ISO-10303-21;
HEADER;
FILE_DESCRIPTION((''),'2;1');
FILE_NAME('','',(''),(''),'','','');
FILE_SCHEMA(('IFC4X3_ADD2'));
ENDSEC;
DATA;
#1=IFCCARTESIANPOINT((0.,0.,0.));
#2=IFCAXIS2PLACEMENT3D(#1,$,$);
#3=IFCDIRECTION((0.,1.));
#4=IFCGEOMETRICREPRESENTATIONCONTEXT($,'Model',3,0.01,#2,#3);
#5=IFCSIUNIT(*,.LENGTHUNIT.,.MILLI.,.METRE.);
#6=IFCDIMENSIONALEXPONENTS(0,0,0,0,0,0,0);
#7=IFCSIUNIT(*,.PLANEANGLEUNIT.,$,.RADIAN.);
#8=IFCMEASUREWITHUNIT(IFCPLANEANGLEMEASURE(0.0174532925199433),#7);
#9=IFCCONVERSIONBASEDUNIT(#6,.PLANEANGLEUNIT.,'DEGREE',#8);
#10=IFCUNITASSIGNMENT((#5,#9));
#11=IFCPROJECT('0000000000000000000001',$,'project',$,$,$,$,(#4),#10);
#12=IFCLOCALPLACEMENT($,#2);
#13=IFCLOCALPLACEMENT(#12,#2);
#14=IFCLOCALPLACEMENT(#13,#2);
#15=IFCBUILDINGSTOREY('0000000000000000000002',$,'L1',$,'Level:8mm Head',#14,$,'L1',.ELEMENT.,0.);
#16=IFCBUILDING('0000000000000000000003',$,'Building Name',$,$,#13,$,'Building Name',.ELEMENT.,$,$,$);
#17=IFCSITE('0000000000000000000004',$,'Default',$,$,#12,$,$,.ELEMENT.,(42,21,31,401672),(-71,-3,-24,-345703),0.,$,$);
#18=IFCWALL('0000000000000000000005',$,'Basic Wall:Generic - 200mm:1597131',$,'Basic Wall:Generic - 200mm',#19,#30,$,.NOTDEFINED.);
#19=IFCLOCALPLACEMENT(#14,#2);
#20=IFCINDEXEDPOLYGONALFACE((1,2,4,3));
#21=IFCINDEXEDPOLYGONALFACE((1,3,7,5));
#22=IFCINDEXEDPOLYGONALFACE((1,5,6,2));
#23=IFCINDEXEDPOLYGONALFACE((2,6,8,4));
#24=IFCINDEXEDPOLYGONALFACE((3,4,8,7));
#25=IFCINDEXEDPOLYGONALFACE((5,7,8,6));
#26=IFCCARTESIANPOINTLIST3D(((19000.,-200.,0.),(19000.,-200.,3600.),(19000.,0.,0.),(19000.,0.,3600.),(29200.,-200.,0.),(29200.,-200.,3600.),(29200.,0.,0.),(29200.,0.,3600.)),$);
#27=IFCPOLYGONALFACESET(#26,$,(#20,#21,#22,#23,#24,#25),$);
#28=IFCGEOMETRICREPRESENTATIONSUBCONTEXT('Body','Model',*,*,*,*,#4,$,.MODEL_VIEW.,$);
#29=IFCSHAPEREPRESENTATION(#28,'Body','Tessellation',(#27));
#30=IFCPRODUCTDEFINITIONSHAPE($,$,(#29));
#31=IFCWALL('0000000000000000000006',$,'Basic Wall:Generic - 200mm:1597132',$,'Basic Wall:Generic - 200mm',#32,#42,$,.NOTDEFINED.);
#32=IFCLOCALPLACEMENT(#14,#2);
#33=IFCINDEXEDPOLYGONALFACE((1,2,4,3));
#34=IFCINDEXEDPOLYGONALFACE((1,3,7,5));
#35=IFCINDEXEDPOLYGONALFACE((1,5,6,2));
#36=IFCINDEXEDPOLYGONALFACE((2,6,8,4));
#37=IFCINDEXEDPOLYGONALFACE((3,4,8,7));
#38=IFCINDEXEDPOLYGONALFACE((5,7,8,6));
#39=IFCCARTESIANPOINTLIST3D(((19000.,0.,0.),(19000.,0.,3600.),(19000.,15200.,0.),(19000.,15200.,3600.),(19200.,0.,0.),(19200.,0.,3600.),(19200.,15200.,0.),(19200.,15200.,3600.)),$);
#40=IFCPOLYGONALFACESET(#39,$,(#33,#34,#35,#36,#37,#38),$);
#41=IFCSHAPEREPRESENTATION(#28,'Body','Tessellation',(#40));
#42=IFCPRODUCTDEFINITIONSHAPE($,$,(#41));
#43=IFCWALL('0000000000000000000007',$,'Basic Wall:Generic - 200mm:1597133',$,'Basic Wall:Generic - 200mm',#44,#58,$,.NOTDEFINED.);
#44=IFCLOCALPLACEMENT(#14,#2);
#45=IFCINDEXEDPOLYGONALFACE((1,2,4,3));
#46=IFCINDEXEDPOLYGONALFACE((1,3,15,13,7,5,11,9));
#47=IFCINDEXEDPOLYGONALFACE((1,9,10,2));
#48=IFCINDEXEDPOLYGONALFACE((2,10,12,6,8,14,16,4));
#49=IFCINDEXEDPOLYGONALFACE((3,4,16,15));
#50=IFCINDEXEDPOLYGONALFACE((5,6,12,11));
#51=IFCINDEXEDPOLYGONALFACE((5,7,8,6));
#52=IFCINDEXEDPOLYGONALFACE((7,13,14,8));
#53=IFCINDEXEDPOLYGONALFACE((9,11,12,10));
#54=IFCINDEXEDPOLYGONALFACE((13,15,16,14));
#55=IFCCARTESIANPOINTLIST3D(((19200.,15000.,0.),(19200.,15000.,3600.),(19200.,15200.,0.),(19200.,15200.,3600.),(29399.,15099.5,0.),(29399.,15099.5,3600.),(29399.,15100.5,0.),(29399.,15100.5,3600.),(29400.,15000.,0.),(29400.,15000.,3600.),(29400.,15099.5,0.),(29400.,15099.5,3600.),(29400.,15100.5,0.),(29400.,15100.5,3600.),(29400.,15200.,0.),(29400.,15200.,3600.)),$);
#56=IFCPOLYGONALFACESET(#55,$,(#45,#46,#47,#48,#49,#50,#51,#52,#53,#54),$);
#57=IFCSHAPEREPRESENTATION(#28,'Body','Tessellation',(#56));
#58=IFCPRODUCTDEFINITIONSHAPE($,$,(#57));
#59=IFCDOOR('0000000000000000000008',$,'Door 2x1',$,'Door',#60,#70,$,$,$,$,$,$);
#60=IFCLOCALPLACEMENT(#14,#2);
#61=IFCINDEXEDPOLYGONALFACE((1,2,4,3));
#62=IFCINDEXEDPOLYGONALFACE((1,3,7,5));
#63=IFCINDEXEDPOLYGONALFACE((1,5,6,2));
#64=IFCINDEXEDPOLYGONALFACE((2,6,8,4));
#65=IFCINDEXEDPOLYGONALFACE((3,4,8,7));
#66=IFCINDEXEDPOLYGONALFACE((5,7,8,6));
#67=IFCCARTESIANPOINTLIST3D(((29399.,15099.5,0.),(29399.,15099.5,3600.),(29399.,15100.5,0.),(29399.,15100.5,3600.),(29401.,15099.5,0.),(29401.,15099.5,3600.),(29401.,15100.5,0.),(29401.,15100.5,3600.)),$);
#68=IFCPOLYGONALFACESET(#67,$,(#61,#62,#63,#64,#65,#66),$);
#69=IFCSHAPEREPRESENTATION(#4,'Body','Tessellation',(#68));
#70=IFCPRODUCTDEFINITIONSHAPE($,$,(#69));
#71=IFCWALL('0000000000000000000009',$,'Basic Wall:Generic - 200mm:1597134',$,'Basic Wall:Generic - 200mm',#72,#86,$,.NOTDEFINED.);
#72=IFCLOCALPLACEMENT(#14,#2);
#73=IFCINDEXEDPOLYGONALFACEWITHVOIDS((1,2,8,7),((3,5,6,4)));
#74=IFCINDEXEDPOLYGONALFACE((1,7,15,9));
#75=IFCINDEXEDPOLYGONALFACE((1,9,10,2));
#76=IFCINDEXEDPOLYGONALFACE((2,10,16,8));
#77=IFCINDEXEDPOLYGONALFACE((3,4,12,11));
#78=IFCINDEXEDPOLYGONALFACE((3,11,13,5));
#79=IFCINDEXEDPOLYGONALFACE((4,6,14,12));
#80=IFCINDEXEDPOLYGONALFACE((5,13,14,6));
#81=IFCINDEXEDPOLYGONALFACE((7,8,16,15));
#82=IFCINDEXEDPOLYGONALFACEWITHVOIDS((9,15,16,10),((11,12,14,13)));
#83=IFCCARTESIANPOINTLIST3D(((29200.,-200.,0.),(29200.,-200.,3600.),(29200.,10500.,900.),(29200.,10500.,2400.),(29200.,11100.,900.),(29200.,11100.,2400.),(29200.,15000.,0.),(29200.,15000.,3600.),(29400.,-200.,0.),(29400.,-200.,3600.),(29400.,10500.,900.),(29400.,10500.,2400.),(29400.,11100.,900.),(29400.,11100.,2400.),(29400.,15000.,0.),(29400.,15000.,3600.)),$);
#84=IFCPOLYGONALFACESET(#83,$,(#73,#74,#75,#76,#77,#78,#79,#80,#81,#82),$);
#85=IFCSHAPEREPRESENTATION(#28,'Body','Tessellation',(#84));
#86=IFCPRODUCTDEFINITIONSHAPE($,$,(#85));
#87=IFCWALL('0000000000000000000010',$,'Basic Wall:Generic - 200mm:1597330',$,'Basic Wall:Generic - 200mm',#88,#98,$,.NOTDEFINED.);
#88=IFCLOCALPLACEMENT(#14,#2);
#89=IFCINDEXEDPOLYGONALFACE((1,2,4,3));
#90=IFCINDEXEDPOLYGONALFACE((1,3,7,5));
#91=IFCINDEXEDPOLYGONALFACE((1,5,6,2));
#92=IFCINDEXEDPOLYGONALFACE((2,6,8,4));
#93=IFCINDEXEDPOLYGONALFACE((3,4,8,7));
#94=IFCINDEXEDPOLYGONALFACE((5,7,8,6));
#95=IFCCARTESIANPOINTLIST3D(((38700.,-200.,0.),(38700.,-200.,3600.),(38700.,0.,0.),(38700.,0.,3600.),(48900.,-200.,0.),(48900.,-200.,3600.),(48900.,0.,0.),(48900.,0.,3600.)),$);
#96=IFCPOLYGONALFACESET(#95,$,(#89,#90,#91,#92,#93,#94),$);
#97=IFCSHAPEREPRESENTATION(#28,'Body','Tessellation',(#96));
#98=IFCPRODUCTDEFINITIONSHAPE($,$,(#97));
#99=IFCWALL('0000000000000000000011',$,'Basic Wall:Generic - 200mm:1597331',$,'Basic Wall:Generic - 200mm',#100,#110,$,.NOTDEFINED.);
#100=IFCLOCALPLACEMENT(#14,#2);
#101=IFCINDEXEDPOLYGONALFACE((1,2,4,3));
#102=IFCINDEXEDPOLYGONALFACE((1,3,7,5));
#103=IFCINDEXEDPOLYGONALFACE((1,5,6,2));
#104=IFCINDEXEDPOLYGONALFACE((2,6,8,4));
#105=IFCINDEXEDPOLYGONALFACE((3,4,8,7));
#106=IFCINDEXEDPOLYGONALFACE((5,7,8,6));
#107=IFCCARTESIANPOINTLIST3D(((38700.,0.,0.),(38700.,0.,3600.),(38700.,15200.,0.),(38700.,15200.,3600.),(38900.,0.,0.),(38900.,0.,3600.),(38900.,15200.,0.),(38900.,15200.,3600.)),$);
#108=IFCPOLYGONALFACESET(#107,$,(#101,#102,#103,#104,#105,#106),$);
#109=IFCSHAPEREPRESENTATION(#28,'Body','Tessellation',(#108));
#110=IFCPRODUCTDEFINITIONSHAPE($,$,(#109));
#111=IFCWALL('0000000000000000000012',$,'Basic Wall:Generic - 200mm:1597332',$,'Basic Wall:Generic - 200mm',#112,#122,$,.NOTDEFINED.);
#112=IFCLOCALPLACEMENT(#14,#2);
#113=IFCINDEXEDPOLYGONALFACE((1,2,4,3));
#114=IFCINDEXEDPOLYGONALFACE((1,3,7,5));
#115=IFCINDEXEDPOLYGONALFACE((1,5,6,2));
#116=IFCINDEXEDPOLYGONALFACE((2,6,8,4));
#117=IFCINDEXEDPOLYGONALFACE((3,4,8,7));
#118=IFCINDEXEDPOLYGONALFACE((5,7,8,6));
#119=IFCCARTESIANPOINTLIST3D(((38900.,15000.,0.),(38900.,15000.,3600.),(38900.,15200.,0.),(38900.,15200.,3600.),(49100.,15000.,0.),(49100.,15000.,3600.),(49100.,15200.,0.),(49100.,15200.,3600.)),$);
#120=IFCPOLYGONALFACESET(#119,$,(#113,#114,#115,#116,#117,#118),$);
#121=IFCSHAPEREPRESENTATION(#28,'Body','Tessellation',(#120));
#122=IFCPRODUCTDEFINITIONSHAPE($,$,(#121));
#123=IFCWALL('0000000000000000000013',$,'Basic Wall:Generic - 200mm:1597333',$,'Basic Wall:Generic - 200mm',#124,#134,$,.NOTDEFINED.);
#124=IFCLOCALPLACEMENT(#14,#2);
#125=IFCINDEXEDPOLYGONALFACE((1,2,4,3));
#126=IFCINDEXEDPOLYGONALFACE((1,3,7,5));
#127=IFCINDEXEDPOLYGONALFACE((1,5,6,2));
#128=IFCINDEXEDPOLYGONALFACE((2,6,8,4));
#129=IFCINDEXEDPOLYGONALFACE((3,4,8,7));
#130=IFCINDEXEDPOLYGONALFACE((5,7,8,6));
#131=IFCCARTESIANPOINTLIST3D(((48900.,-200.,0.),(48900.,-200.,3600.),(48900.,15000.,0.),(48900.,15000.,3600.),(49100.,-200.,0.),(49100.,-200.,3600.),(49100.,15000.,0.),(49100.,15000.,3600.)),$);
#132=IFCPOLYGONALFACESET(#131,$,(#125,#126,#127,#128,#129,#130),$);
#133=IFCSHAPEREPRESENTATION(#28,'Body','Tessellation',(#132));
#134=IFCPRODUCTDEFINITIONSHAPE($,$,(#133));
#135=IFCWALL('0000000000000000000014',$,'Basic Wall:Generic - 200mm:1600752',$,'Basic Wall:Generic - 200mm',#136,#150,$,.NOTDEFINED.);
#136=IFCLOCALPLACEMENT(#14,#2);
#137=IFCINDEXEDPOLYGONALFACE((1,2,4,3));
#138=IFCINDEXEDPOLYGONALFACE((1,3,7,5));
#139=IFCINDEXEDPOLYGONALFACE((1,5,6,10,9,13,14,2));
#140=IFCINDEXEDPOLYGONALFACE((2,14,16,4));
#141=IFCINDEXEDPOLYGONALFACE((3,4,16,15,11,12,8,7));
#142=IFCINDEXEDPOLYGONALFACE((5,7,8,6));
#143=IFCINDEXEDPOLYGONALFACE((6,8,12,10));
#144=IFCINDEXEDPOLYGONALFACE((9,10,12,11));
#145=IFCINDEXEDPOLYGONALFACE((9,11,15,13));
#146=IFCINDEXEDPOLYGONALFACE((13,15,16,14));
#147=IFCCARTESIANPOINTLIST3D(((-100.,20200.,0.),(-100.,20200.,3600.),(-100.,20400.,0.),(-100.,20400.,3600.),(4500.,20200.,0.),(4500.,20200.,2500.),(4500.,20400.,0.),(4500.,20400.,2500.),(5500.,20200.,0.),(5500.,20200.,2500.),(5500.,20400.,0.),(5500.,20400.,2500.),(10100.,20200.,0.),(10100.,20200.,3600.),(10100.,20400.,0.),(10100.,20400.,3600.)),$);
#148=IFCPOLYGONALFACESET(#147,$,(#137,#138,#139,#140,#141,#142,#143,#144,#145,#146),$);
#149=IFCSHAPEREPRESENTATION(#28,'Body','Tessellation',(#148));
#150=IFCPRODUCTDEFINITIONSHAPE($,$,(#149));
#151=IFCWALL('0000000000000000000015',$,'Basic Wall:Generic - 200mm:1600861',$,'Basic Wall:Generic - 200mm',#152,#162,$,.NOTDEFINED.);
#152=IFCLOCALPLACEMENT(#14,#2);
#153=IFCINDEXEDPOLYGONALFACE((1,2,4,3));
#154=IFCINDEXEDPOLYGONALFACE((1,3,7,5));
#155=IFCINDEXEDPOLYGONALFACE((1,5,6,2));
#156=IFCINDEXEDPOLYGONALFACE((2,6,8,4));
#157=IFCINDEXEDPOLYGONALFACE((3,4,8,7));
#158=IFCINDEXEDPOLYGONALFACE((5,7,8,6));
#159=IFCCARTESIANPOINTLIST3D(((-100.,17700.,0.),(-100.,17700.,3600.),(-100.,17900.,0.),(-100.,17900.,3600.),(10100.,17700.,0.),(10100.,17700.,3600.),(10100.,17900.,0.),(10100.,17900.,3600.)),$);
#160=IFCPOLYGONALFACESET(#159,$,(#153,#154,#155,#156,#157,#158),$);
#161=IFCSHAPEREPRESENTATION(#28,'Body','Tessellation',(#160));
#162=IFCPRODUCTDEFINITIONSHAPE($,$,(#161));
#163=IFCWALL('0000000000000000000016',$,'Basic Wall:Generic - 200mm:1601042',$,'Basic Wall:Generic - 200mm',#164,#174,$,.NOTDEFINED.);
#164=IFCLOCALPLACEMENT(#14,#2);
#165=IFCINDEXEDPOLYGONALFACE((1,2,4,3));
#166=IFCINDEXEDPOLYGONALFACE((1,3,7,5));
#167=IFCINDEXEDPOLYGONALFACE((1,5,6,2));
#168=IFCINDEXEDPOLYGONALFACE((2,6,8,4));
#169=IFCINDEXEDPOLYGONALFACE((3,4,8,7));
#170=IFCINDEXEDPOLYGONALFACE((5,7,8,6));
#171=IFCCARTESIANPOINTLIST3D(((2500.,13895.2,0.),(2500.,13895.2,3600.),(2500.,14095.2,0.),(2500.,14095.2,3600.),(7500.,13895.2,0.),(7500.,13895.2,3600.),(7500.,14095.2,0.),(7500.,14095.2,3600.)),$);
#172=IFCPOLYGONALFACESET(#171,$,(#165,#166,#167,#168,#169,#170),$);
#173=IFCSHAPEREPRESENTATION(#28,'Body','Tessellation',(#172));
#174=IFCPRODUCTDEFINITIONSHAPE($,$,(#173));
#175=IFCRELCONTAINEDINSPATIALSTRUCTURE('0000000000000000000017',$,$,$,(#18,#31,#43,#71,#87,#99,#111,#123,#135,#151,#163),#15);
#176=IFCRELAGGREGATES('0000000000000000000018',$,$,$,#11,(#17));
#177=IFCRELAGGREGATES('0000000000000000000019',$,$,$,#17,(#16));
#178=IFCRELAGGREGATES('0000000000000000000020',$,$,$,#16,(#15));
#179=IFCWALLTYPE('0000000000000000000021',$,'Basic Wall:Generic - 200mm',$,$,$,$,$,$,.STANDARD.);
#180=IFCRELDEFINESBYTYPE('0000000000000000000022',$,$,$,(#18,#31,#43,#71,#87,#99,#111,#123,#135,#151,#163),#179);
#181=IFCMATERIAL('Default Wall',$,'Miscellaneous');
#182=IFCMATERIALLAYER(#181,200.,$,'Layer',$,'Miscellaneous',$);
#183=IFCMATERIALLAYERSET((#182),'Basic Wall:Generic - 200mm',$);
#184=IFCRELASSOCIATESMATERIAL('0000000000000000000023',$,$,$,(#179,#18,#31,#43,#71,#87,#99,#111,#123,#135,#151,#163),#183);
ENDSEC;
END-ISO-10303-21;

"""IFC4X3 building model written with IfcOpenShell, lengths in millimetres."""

from ifc_helpers import new_model, entity, si_unit, converted_unit, direction, frame, frame_2d, origin, origin_2d, origin_2d_with_axis, place, context, subcontext, project, spatial, rectangle, extrude, material, layer, layer_set, type_object, element, fill, save


model = new_model("IFC4X3")

# Units and contexts
model_context = context("Model", 3, precision=0.01, world=origin(), true_north=direction((0.0, 1.0)))
body_context = subcontext(model_context, "Body", "Model", "MODEL_VIEW")
ifc_project = project(units=[si_unit("LENGTHUNIT", "METRE", prefix="MILLI"), converted_unit("PLANEANGLEUNIT", "DEGREE", entity("IfcPlaneAngleMeasure", 0.0174532925199433), si_unit("PLANEANGLEUNIT", "RADIAN"), dimensions=[0, 0, 0, 0, 0, 0, 0])], contexts=[model_context])

# Site, building, storey
site_placement = place(None, origin())
site = spatial("IfcSite", under=ifc_project, at=site_placement, Name="Default", CompositionType="ELEMENT", RefLatitude=(42, 21, 31, 401672), RefLongitude=(-71, -3, -24, -345703), RefElevation=0.0)
building_placement = place(site_placement, origin())
building = spatial("IfcBuilding", under=site, at=building_placement, Name="Building Name", LongName="Building Name", CompositionType="ELEMENT")
storey_placement = place(building_placement, origin())
storey = spatial("IfcBuildingStorey", under=building, at=storey_placement, Name="L1", ObjectType="Level:8mm Head", LongName="L1", CompositionType="ELEMENT", Elevation=0.0)

# Walls
ifc_material_1 = material(Name="Default Wall", Category="Miscellaneous")
ifc_layer_1 = layer(ifc_material_1, 200.0, Name="Layer", Category="Miscellaneous")
ifc_layer_set_1 = layer_set([ifc_layer_1], Name="Basic Wall:Generic - 200mm")
wall_type_1 = type_object("IfcWallType", Name="Basic Wall:Generic - 200mm", PredefinedType="STANDARD", material=ifc_layer_set_1)
wall_1_placement = place(storey_placement, frame((19000.0, -100.0, 0.0)))
element("IfcWall", 1, at=wall_1_placement, inside=storey, type_object=wall_type_1, material=ifc_layer_set_1, Name="Basic Wall:Generic - 200mm:1597131", ObjectType="Basic Wall:Generic - 200mm", PredefinedType="NOTDEFINED", context=body_context, shape_type="SweptSolid", body=[
    extrude(rectangle(XDim=10200.0, YDim=200.0, at=frame_2d((5100.0, 0.0), x_axis=(-1.0, 0.0))), origin(), (0.0, 0.0, 1.0), 3600.0),
])
wall_2_placement = place(storey_placement, frame((19100.0, 15200.0, 0.0), z_axis=(0.0, 0.0, 1.0), x_axis=(0.0, -1.0, 0.0)))
element("IfcWall", 2, at=wall_2_placement, inside=storey, type_object=wall_type_1, material=ifc_layer_set_1, Name="Basic Wall:Generic - 200mm:1597132", ObjectType="Basic Wall:Generic - 200mm", PredefinedType="NOTDEFINED", context=body_context, shape_type="SweptSolid", body=[
    extrude(rectangle(XDim=15200.0, YDim=200.0, at=frame_2d((7600.0, 0.0), x_axis=(-1.0, 0.0))), origin(), (0.0, 0.0, 1.0), 3600.0),
])

# Wall, opening, door
wall_3_placement = place(storey_placement, frame((29400.0, 15100.0, 0.0), z_axis=(0.0, 0.0, 1.0), x_axis=(-1.0, 0.0, 0.0)))
wall_3 = element("IfcWall", 3, at=wall_3_placement, inside=storey, type_object=wall_type_1, material=ifc_layer_set_1, Name="Basic Wall:Generic - 200mm:1597133", ObjectType="Basic Wall:Generic - 200mm", PredefinedType="NOTDEFINED", context=body_context, shape_type="SweptSolid", body=[
    extrude(rectangle(XDim=10200.0, YDim=200.0, at=frame_2d((5100.0, 0.0), x_axis=(-1.0, 0.0))), origin(), (0.0, 0.0, 1.0), 3600.0),
])
placement = place(wall_3_placement, origin())
opening_1 = element("IfcOpeningElement", 4, at=placement, cuts=wall_3, ObjectType="Opening", context=model_context, shape_type="SweptSolid", body=[
    extrude(rectangle(XDim=2.0, YDim=1.0, at=origin_2d()), origin(), (0.0, 0.0, 1.0), 3600.0),
])
door = element("IfcDoor", 5, at=placement, Name="Door 2x1", ObjectType="Door", context=model_context, shape_type="SweptSolid", body=[
    extrude(rectangle(XDim=2.0, YDim=1.0, at=origin_2d()), origin(), (0.0, 0.0, 1.0), 3600.0),
])
fill(opening_1, door)

# Wall, opening
wall_4_placement = place(storey_placement, frame((29300.0, -200.0, 0.0), z_axis=(0.0, 0.0, 1.0), x_axis=(0.0, 1.0, 0.0)))
wall_4 = element("IfcWall", 6, at=wall_4_placement, inside=storey, type_object=wall_type_1, material=ifc_layer_set_1, Name="Basic Wall:Generic - 200mm:1597134", ObjectType="Basic Wall:Generic - 200mm", PredefinedType="NOTDEFINED", context=body_context, shape_type="SweptSolid", body=[
    extrude(rectangle(XDim=15200.0, YDim=200.0, at=frame_2d((7600.0, 0.0), x_axis=(-1.0, 0.0))), origin(), (0.0, 0.0, 1.0), 3600.0),
])
opening_2_placement = place(wall_4_placement, frame((11300.0, 100.0, 900.0)))
element("IfcOpeningElement", 7, at=opening_2_placement, cuts=wall_4, PredefinedType="OPENING", context=body_context, shape_type="SweptSolid", body=[
    extrude(rectangle(XDim=1500.0, YDim=600.0, at=frame_2d((750.0, 300.0), x_axis=(-1.0, 0.0))), frame((0.0, 0.0, 0.0), z_axis=(0.0, -1.0, 0.0), x_axis=(0.0, 0.0, 1.0)), (0.0, 0.0, 1.0), 200.0),
])

# Walls
wall_5_placement = place(storey_placement, frame((38700.0, -100.0, 0.0)))
element("IfcWall", 8, at=wall_5_placement, inside=storey, type_object=wall_type_1, material=ifc_layer_set_1, Name="Basic Wall:Generic - 200mm:1597330", ObjectType="Basic Wall:Generic - 200mm", PredefinedType="NOTDEFINED", context=body_context, shape_type="SweptSolid", body=[
    extrude(rectangle(XDim=10200.0, YDim=200.0, at=frame_2d((5100.0, 0.0), x_axis=(-1.0, 0.0))), origin(), (0.0, 0.0, 1.0), 3600.0),
])
wall_6_placement = place(storey_placement, frame((38800.0, 15200.0, 0.0), z_axis=(0.0, 0.0, 1.0), x_axis=(0.0, -1.0, 0.0)))
element("IfcWall", 9, at=wall_6_placement, inside=storey, type_object=wall_type_1, material=ifc_layer_set_1, Name="Basic Wall:Generic - 200mm:1597331", ObjectType="Basic Wall:Generic - 200mm", PredefinedType="NOTDEFINED", context=body_context, shape_type="SweptSolid", body=[
    extrude(rectangle(XDim=15200.0, YDim=200.0, at=frame_2d((7600.0, 0.0), x_axis=(-1.0, 0.0))), origin(), (0.0, 0.0, 1.0), 3600.0),
])
wall_7_placement = place(storey_placement, frame((49100.0, 15100.0, 0.0), z_axis=(0.0, 0.0, 1.0), x_axis=(-1.0, 0.0, 0.0)))
element("IfcWall", 10, at=wall_7_placement, inside=storey, type_object=wall_type_1, material=ifc_layer_set_1, Name="Basic Wall:Generic - 200mm:1597332", ObjectType="Basic Wall:Generic - 200mm", PredefinedType="NOTDEFINED", context=body_context, shape_type="SweptSolid", body=[
    extrude(rectangle(XDim=10200.0, YDim=200.0, at=frame_2d((5100.0, 0.0), x_axis=(-1.0, 0.0))), origin(), (0.0, 0.0, 1.0), 3600.0),
])
wall_8_placement = place(storey_placement, frame((49000.0, -200.0, 0.0), z_axis=(0.0, 0.0, 1.0), x_axis=(0.0, 1.0, 0.0)))
element("IfcWall", 11, at=wall_8_placement, inside=storey, type_object=wall_type_1, material=ifc_layer_set_1, Name="Basic Wall:Generic - 200mm:1597333", ObjectType="Basic Wall:Generic - 200mm", PredefinedType="NOTDEFINED", context=body_context, shape_type="SweptSolid", body=[
    extrude(rectangle(XDim=15200.0, YDim=200.0, at=frame_2d((7600.0, 0.0), x_axis=(-1.0, 0.0))), origin(), (0.0, 0.0, 1.0), 3600.0),
])

# Wall, opening
wall_9_placement = place(storey_placement, frame((10100.0, 20300.0, 0.0), z_axis=(0.0, 0.0, 1.0), x_axis=(-1.0, 0.0, 0.0)))
wall_9 = element("IfcWall", 12, at=wall_9_placement, inside=storey, type_object=wall_type_1, material=ifc_layer_set_1, Name="Basic Wall:Generic - 200mm:1600752", ObjectType="Basic Wall:Generic - 200mm", PredefinedType="NOTDEFINED", context=body_context, shape_type="SweptSolid", body=[
    extrude(rectangle(XDim=10200.0, YDim=200.0, at=frame_2d((5100.0, 0.0), x_axis=(1.0, 0.0))), origin(), (0.0, 0.0, 1.0), 3600.0),
])
opening_3_placement = place(wall_9_placement, frame((5600.0, 100.0, 0.0)))
element("IfcOpeningElement", 13, at=opening_3_placement, cuts=wall_9, PredefinedType="OPENING", context=body_context, shape_type="SweptSolid", body=[
    extrude(rectangle(XDim=2500.0, YDim=1000.0, at=origin_2d_with_axis()), frame((-500.0, -200.0, 1250.0), z_axis=(0.0, 1.0, 0.0), x_axis=(0.0, 0.0, -1.0)), (0.0, 0.0, 1.0), 200.0),
])

# Walls
wall_10_placement = place(storey_placement, frame((10100.0, 17800.0, 0.0), z_axis=(0.0, 0.0, 1.0), x_axis=(-1.0, 0.0, 0.0)))
element("IfcWall", 14, at=wall_10_placement, inside=storey, type_object=wall_type_1, material=ifc_layer_set_1, Name="Basic Wall:Generic - 200mm:1600861", ObjectType="Basic Wall:Generic - 200mm", PredefinedType="NOTDEFINED", context=body_context, shape_type="SweptSolid", body=[
    extrude(rectangle(XDim=10200.0, YDim=200.0, at=frame_2d((5100.0, 0.0), x_axis=(-1.0, 0.0))), origin(), (0.0, 0.0, 1.0), 3600.0),
])
wall_11_placement = place(storey_placement, frame((7500.0, 13995.2, 0.0), z_axis=(0.0, 0.0, 1.0), x_axis=(-1.0, 0.0, 0.0)))
element("IfcWall", 15, at=wall_11_placement, inside=storey, type_object=wall_type_1, material=ifc_layer_set_1, Name="Basic Wall:Generic - 200mm:1601042", ObjectType="Basic Wall:Generic - 200mm", PredefinedType="NOTDEFINED", context=body_context, shape_type="SweptSolid", body=[
    extrude(rectangle(XDim=5000.0, YDim=200.0, at=frame_2d((2500.0, 0.0), x_axis=(-1.0, 0.0))), origin(), (0.0, 0.0, 1.0), 3600.0),
])

save(model, "model.ifc")
